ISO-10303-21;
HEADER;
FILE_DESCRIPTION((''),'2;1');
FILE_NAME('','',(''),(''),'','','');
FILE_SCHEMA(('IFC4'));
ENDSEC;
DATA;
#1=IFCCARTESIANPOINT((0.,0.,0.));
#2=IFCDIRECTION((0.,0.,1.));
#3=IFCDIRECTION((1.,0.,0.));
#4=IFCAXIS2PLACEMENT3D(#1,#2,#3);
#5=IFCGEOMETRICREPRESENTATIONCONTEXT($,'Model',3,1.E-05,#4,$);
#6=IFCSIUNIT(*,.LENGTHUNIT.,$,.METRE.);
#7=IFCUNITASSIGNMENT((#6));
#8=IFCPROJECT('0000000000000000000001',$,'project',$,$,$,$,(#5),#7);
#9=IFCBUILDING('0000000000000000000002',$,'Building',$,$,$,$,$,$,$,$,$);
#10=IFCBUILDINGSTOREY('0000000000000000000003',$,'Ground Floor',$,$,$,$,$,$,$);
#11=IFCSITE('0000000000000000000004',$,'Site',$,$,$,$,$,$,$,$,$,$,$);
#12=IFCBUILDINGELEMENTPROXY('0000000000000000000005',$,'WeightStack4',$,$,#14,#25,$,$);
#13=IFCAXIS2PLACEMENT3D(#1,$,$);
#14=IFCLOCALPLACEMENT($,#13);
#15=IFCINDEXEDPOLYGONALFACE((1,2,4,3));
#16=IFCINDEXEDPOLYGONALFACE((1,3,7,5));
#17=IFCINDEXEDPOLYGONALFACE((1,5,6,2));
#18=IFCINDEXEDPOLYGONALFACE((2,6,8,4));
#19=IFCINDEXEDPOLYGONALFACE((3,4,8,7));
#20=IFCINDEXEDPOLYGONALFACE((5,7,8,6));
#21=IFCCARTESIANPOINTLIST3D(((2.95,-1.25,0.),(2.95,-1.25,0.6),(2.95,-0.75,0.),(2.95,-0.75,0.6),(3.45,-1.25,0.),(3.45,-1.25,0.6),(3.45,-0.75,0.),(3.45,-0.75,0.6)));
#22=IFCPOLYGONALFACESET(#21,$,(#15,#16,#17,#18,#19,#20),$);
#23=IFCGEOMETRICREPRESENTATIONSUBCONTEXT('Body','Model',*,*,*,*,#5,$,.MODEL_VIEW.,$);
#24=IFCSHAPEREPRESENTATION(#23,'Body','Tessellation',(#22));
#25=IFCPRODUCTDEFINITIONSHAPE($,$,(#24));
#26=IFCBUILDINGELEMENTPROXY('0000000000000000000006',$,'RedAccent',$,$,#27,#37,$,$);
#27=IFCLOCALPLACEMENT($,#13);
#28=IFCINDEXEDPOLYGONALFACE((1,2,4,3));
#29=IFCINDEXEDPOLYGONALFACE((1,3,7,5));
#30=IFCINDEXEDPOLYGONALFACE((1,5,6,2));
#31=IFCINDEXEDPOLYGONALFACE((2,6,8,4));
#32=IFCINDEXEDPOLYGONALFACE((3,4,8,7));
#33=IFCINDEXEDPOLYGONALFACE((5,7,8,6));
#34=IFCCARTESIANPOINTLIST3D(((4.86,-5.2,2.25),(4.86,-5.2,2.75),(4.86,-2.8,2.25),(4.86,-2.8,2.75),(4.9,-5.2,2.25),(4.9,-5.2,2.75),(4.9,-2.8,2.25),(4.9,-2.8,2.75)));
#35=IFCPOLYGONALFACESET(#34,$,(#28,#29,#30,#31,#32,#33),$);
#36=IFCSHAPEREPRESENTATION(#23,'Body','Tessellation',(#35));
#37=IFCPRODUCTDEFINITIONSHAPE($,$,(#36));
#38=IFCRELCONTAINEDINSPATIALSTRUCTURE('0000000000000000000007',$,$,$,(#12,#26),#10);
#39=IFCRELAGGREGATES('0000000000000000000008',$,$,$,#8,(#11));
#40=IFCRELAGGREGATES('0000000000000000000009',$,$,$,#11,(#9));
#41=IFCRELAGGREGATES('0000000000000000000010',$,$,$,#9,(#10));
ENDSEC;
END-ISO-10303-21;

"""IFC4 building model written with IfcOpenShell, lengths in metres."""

from ifc_helpers import new_model, si_unit, frame, origin_with_axes, origin_2d, place, context, subcontext, project, spatial, rectangle, extrude, element, save


model = new_model("IFC4")

# Units and contexts
model_context = context("Model", 3, precision=1e-05, world=origin_with_axes())
body_context = subcontext(model_context, "Body", "Model", "MODEL_VIEW")
ifc_project = project(units=[si_unit("LENGTHUNIT", "METRE")], contexts=[model_context])

# Site, building, storey
site = spatial("IfcSite", under=ifc_project, Name="Site")
building = spatial("IfcBuilding", under=site, Name="Building")
storey = spatial("IfcBuildingStorey", under=building, Name="Ground Floor")

# Building element proxies
for number, where, z_axis, x_axis, name in (
    (1, (3.2, -1.0, 0.3), (0.0, 0.0, 1.0), (1.0, 0.0, 0.0), "WeightStack4"),
):
    element("IfcBuildingElementProxy", number, at=place(None, frame(where, z_axis=z_axis, x_axis=x_axis)), inside=storey, Name=name, context=body_context, shape_type="SweptSolid", body=[
        extrude(rectangle(XDim=0.5, YDim=0.5, at=origin_2d()), frame((0.0, 0.0, -0.3)), (0.0, 0.0, 1.0), 0.6),
    ])
proxy_1_placement = place(None, frame((4.88, -4.0, 2.5), z_axis=(0.0, 0.0, 1.0), x_axis=(1.0, 0.0, 0.0)))
element("IfcBuildingElementProxy", 2, at=proxy_1_placement, inside=storey, Name="RedAccent", context=body_context, shape_type="SweptSolid", body=[
    extrude(rectangle(XDim=0.04, YDim=2.4, at=origin_2d()), frame((0.0, 0.0, -0.25)), (0.0, 0.0, 1.0), 0.5),
])

save(model, "model.ifc")
